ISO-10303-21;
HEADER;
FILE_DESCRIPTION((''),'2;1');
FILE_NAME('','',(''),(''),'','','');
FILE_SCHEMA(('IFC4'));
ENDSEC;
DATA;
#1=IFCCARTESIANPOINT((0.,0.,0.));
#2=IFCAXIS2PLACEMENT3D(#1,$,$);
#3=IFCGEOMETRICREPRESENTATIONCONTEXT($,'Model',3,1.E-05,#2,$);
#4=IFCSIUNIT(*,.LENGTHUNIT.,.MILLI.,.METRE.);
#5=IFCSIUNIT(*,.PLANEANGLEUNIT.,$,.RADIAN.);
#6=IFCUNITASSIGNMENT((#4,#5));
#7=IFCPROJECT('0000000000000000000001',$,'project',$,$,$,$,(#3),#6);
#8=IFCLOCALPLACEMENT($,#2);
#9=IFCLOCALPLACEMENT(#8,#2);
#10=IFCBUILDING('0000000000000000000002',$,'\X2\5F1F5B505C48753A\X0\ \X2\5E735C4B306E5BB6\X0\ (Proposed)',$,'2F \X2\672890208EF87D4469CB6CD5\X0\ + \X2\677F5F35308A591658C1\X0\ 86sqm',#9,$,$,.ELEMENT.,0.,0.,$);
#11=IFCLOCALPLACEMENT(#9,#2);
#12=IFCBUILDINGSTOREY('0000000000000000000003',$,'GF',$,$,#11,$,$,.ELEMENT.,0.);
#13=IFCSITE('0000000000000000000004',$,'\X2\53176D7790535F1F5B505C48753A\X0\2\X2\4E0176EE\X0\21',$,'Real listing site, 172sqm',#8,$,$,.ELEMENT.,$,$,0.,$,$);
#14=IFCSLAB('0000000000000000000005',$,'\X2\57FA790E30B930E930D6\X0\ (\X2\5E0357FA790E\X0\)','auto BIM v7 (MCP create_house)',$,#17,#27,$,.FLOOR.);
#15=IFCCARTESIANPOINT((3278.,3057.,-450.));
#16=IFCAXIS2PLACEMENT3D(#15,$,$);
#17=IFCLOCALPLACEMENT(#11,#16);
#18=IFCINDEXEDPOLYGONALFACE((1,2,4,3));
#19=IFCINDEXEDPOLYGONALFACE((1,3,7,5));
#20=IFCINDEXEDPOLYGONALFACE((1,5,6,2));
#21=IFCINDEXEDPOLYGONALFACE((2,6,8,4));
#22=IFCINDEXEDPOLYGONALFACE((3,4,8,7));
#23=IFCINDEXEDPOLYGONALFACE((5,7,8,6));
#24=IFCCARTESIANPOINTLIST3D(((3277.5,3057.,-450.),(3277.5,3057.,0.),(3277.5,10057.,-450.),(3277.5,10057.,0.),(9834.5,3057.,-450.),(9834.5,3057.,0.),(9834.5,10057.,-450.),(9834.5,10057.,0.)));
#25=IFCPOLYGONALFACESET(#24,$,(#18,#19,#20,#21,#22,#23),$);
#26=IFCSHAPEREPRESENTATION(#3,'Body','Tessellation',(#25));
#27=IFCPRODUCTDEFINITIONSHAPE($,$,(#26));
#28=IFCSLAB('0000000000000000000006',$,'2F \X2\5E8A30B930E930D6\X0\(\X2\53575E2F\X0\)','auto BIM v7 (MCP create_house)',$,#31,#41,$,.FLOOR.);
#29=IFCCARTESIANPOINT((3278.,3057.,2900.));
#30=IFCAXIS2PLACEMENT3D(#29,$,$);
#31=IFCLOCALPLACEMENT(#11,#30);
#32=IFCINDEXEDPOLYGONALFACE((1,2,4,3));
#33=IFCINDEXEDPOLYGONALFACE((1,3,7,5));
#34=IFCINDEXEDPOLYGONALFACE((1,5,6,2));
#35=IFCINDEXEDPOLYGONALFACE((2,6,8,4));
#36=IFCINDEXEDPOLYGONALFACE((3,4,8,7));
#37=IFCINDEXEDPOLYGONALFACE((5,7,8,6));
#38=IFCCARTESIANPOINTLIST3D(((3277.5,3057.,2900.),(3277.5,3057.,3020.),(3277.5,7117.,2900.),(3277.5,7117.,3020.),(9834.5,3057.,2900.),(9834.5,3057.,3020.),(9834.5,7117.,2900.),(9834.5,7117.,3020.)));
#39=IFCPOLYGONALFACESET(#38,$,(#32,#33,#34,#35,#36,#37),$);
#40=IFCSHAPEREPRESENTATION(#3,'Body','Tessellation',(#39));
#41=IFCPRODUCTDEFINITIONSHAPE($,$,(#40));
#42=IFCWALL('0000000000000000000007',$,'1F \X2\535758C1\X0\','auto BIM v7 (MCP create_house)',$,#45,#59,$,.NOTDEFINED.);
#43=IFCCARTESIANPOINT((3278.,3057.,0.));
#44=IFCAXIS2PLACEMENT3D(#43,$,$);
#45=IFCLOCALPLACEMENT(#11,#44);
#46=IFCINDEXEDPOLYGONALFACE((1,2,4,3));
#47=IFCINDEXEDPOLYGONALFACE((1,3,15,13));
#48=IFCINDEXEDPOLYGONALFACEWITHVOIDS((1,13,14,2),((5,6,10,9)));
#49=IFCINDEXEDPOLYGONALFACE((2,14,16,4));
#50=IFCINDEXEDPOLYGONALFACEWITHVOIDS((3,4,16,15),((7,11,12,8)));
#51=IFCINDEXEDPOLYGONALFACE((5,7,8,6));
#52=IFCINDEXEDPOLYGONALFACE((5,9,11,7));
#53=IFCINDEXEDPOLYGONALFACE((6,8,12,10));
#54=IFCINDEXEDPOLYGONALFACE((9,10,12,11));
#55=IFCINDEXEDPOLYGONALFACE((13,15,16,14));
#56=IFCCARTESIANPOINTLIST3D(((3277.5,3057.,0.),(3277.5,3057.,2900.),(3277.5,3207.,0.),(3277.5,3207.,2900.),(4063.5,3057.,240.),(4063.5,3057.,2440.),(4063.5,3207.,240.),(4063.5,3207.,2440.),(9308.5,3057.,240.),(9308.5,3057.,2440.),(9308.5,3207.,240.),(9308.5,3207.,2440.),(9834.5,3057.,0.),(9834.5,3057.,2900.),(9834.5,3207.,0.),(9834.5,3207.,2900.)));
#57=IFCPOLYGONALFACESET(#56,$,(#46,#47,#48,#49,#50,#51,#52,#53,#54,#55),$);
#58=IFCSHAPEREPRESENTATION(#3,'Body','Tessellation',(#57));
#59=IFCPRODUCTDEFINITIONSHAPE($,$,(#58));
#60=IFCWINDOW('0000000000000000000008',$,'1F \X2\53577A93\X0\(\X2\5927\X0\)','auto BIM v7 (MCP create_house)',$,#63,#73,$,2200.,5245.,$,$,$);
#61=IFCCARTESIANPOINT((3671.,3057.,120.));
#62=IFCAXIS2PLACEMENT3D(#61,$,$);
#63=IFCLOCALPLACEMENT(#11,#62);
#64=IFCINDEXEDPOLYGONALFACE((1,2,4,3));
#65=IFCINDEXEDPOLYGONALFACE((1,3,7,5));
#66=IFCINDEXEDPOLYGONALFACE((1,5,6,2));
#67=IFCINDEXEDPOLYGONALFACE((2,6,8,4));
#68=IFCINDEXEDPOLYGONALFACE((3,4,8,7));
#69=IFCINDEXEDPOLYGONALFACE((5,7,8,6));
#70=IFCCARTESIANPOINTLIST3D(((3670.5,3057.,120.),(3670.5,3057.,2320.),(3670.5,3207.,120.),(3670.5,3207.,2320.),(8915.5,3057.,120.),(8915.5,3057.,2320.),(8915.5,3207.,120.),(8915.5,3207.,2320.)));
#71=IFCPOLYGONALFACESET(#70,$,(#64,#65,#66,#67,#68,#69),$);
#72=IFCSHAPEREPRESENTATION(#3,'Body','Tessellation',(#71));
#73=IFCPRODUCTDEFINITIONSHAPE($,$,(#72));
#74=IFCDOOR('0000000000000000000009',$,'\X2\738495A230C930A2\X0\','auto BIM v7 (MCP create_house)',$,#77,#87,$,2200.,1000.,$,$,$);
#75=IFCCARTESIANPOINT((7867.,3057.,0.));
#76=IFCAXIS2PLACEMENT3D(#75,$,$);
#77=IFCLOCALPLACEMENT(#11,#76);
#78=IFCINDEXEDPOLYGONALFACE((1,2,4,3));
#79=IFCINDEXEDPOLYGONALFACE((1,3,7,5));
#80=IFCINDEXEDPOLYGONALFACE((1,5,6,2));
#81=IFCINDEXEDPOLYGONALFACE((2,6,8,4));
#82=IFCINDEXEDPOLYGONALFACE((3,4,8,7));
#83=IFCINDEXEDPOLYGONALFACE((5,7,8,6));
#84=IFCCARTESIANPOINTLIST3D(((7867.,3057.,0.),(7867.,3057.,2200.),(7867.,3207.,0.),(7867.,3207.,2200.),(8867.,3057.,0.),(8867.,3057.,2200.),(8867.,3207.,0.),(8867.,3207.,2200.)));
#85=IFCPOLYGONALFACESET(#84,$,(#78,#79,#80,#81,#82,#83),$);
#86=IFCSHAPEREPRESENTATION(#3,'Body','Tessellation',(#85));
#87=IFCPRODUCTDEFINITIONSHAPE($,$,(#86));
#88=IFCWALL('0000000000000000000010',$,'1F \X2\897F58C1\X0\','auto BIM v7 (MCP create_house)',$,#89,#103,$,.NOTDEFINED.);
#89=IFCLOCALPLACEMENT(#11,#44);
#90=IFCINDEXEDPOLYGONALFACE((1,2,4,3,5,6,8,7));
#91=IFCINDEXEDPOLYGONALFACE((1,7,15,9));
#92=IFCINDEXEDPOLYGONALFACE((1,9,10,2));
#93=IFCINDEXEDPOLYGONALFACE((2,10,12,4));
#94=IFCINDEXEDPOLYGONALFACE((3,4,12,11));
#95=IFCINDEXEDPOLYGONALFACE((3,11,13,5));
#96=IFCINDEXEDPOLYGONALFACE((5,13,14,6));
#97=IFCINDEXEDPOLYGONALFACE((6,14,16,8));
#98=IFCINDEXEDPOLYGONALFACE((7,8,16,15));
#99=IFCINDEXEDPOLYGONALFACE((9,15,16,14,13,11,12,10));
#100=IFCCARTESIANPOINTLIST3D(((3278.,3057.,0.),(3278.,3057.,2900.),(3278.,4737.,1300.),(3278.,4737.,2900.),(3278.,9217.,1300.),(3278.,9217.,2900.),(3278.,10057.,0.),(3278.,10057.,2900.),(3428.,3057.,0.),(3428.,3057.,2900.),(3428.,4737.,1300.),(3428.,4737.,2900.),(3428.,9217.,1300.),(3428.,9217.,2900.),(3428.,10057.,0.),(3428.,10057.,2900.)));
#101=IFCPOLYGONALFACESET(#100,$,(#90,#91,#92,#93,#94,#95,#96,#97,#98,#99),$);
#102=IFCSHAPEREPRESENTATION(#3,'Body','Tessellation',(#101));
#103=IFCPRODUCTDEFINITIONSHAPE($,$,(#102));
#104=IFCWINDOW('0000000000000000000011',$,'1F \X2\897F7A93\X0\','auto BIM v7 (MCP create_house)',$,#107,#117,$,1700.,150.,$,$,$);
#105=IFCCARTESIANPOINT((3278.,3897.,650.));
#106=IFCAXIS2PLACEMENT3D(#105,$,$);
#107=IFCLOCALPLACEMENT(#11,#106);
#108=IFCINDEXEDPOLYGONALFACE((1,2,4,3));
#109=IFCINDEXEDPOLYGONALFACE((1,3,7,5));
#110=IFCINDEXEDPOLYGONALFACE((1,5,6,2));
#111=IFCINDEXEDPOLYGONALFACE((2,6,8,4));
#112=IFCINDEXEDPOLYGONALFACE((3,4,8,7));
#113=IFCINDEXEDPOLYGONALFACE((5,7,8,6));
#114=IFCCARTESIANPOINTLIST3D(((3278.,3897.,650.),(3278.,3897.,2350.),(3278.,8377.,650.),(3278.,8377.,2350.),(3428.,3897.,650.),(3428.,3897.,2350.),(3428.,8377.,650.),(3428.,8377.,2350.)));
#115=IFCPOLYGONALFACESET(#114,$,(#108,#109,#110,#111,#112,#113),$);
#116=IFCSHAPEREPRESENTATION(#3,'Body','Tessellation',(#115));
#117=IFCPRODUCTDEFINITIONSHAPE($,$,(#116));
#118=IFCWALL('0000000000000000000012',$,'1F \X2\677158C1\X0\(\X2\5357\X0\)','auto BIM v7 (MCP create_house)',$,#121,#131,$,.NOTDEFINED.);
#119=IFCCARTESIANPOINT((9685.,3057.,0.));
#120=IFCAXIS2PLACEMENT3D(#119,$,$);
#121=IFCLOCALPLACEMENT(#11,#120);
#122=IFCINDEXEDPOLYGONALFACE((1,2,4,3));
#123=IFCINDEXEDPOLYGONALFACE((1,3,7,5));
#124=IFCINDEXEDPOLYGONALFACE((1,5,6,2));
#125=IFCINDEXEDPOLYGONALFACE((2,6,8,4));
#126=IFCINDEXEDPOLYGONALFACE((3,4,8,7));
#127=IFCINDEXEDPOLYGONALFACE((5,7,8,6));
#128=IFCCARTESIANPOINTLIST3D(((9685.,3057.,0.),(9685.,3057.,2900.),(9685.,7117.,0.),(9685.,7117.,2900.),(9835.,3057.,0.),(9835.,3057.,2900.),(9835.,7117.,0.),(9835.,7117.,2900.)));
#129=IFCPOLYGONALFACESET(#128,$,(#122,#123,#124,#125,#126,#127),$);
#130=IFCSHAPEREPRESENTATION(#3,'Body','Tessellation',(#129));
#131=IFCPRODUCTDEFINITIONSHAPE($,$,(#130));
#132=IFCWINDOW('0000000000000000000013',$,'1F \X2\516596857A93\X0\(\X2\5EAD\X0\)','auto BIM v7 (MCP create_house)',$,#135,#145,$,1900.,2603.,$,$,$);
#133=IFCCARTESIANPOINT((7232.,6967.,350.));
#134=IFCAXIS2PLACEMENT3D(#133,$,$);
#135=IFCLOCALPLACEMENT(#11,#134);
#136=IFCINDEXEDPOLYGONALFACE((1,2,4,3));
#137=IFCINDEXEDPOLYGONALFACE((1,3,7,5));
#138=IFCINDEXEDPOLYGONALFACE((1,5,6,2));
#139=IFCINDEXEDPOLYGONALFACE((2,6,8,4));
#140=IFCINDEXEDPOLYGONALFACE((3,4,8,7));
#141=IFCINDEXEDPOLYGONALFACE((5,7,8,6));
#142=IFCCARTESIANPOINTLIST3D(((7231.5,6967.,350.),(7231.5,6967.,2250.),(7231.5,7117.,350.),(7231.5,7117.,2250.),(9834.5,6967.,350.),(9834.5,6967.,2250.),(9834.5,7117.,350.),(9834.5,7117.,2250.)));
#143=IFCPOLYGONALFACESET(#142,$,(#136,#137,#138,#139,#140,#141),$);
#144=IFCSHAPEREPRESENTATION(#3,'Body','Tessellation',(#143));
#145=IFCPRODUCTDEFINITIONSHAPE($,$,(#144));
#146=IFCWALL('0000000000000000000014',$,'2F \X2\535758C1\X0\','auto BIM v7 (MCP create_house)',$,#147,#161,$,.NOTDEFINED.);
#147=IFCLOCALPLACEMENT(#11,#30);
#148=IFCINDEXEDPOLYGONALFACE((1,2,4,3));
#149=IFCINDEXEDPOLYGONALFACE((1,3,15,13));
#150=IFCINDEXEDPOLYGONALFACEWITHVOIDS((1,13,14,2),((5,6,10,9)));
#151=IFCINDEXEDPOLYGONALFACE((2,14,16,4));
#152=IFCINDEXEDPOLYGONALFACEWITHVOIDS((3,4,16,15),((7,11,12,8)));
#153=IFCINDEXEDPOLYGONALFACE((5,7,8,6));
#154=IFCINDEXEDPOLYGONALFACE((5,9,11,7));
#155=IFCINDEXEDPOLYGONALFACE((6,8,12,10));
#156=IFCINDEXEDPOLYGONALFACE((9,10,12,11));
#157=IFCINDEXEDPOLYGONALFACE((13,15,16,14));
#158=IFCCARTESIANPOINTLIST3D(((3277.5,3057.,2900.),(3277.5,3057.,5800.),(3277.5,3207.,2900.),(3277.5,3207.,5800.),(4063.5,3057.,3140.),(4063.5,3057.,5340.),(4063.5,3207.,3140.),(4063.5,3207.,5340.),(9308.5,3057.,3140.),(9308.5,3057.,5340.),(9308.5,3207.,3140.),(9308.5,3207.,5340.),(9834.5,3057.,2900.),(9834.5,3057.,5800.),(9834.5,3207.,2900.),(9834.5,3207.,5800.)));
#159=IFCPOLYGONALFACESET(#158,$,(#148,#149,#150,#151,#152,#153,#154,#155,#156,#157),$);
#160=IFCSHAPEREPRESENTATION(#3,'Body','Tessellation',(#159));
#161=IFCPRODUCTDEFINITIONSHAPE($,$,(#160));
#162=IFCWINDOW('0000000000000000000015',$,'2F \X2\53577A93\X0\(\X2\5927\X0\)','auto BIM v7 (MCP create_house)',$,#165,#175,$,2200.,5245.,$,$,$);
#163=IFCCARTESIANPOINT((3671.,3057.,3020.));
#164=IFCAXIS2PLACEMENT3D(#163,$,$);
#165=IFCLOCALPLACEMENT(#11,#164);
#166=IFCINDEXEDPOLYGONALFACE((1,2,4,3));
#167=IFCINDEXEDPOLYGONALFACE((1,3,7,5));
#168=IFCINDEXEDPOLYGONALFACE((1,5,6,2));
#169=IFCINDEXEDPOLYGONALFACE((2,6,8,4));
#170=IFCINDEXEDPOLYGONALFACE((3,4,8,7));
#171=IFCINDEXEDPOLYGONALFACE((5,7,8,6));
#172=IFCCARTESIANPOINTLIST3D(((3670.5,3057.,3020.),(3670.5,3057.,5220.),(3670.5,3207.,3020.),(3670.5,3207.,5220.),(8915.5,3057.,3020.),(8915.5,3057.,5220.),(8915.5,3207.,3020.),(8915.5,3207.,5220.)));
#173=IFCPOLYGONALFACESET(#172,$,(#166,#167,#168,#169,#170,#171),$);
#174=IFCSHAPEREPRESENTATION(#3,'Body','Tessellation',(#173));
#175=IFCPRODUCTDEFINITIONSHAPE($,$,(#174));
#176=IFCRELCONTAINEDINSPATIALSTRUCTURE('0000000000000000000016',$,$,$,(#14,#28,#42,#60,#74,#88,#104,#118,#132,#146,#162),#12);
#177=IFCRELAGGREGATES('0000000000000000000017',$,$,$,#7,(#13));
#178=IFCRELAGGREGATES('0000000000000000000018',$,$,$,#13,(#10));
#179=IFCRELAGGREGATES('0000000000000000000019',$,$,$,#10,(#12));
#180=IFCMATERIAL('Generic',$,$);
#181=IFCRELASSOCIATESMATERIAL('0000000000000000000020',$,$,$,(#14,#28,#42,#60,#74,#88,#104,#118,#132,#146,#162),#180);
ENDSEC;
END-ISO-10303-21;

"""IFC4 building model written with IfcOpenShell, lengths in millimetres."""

from ifc_helpers import new_model, si_unit, frame, frame_2d, origin, place, context, project, spatial, rectangle, extrude, material, element, fill, save


model = new_model("IFC4")

# Units and contexts
model_context = context("Model", 3, precision=1e-05, world=origin())
ifc_project = project(units=[si_unit("LENGTHUNIT", "METRE", prefix="MILLI"), si_unit("PLANEANGLEUNIT", "RADIAN")], contexts=[model_context])

# Site, building, storey
site_placement = place(None, origin())
site = spatial("IfcSite", under=ifc_project, at=site_placement, Name="北海道弟子屈町2丁目21", ObjectType="Real listing site, 172sqm", CompositionType="ELEMENT", RefElevation=0.0)
building_placement = place(site_placement, origin())
building = spatial("IfcBuilding", under=site, at=building_placement, Name="弟子屈町 平屋の家 (Proposed)", ObjectType="2F 木造軸組構法 + 板張り外壁 86sqm", CompositionType="ELEMENT", ElevationOfRefHeight=0.0, ElevationOfTerrain=0.0)
storey_placement = place(building_placement, origin())
storey = spatial("IfcBuildingStorey", under=building, at=storey_placement, Name="GF", CompositionType="ELEMENT", Elevation=0.0)

# Slabs
ifc_material = material(Name="Generic")
slab_1_placement = place(storey_placement, frame((3278.0, 3057.0, -450.0)))
element("IfcSlab", 1, at=slab_1_placement, inside=storey, material=ifc_material, Name="基礎スラブ (布基礎)", Description="auto BIM v7 (MCP create_house)", PredefinedType="FLOOR", context=model_context, shape_type="SweptSolid", body=[
    extrude(rectangle(XDim=6557.0, YDim=7000.0, at=frame_2d((3278.0, 3500.0))), frame((3278.0, 3057.0, -450.0)), (0.0, 0.0, 1.0), 450.0),
])
slab_2_placement = place(storey_placement, frame((3278.0, 3057.0, 2900.0)))
element("IfcSlab", 2, at=slab_2_placement, inside=storey, material=ifc_material, Name="2F 床スラブ(南帯)", Description="auto BIM v7 (MCP create_house)", PredefinedType="FLOOR", context=model_context, shape_type="SweptSolid", body=[
    extrude(rectangle(XDim=6557.0, YDim=4060.0, at=frame_2d((3278.0, 2030.0))), frame((3278.0, 3057.0, 2900.0)), (0.0, 0.0, 1.0), 120.0),
])

# Wall, openings, window, door
wall_1_placement = place(storey_placement, frame((3278.0, 3057.0, 0.0)))
wall_1 = element("IfcWall", 3, at=wall_1_placement, inside=storey, material=ifc_material, Name="1F 南壁", Description="auto BIM v7 (MCP create_house)", PredefinedType="NOTDEFINED", context=model_context, shape_type="SweptSolid", body=[
    extrude(rectangle(XDim=6557.0, YDim=150.0, at=frame_2d((3278.0, 75.0))), frame((3278.0, 3057.0, 0.0)), (0.0, 0.0, 1.0), 2900.0),
])
opening_1_placement = place(storey_placement, frame((3671.0, 3057.0, 120.0)))
opening_1 = element("IfcOpeningElement", 4, at=opening_1_placement, cuts=wall_1, PredefinedType="NOTDEFINED", context=model_context, shape_type="SweptSolid", body=[
    extrude(rectangle(XDim=5245.0, YDim=150.0, at=frame_2d((2622.0, 75.0))), frame((3671.0, 3057.0, 120.0)), (0.0, 0.0, 1.0), 2200.0),
])
opening_2_placement = place(storey_placement, frame((7867.0, 3057.0, 0.0)))
opening_2 = element("IfcOpeningElement", 5, at=opening_2_placement, cuts=wall_1, PredefinedType="NOTDEFINED", context=model_context, shape_type="SweptSolid", body=[
    extrude(rectangle(XDim=1000.0, YDim=150.0, at=frame_2d((500.0, 75.0))), frame((7867.0, 3057.0, 0.0)), (0.0, 0.0, 1.0), 2200.0),
])
window_1_placement = place(storey_placement, frame((3671.0, 3057.0, 120.0)))
window_1 = element("IfcWindow", 6, at=window_1_placement, inside=storey, material=ifc_material, Name="1F 南窓(大)", Description="auto BIM v7 (MCP create_house)", OverallHeight=2200.0, OverallWidth=5245.0, context=model_context, shape_type="SweptSolid", body=[
    extrude(rectangle(XDim=5245.0, YDim=150.0, at=frame_2d((2622.0, 75.0))), frame((3671.0, 3057.0, 120.0)), (0.0, 0.0, 1.0), 2200.0),
])
fill(opening_1, window_1)
door_placement = place(storey_placement, frame((7867.0, 3057.0, 0.0)))
door = element("IfcDoor", 7, at=door_placement, inside=storey, material=ifc_material, Name="玄関ドア", Description="auto BIM v7 (MCP create_house)", OverallHeight=2200.0, OverallWidth=1000.0, context=model_context, shape_type="SweptSolid", body=[
    extrude(rectangle(XDim=1000.0, YDim=150.0, at=frame_2d((500.0, 75.0))), frame((7867.0, 3057.0, 0.0)), (0.0, 0.0, 1.0), 2200.0),
])
fill(opening_2, door)

# Walls, openings, windows
wall_2_placement = place(storey_placement, frame((3278.0, 3057.0, 0.0)))
wall_2 = element("IfcWall", 8, at=wall_2_placement, inside=storey, material=ifc_material, Name="1F 西壁", Description="auto BIM v7 (MCP create_house)", PredefinedType="NOTDEFINED", context=model_context, shape_type="SweptSolid", body=[
    extrude(rectangle(XDim=150.0, YDim=7000.0, at=frame_2d((75.0, 3500.0))), frame((3278.0, 3057.0, 0.0)), (0.0, 0.0, 1.0), 2900.0),
])
opening_3_placement = place(storey_placement, frame((3278.0, 3897.0, 650.0)))
opening_3 = element("IfcOpeningElement", 9, at=opening_3_placement, cuts=wall_2, PredefinedType="NOTDEFINED", context=model_context, shape_type="SweptSolid", body=[
    extrude(rectangle(XDim=150.0, YDim=4480.0, at=frame_2d((75.0, 2240.0))), frame((3278.0, 3897.0, 650.0)), (0.0, 0.0, 1.0), 1700.0),
])
window_2_placement = place(storey_placement, frame((3278.0, 3897.0, 650.0)))
window_2 = element("IfcWindow", 10, at=window_2_placement, inside=storey, material=ifc_material, Name="1F 西窓", Description="auto BIM v7 (MCP create_house)", OverallHeight=1700.0, OverallWidth=150.0, context=model_context, shape_type="SweptSolid", body=[
    extrude(rectangle(XDim=150.0, YDim=4480.0, at=frame_2d((75.0, 2240.0))), frame((3278.0, 3897.0, 650.0)), (0.0, 0.0, 1.0), 1700.0),
])
fill(opening_3, window_2)
wall_3_placement = place(storey_placement, frame((9685.0, 3057.0, 0.0)))
wall_3 = element("IfcWall", 11, at=wall_3_placement, inside=storey, material=ifc_material, Name="1F 東壁(南)", Description="auto BIM v7 (MCP create_house)", PredefinedType="NOTDEFINED", context=model_context, shape_type="SweptSolid", body=[
    extrude(rectangle(XDim=150.0, YDim=4060.0, at=frame_2d((75.0, 2030.0))), frame((9685.0, 3057.0, 0.0)), (0.0, 0.0, 1.0), 2900.0),
])
opening_4_placement = place(storey_placement, frame((7232.0, 6967.0, 350.0)))
opening_4 = element("IfcOpeningElement", 12, at=opening_4_placement, cuts=wall_3, PredefinedType="NOTDEFINED", context=model_context, shape_type="SweptSolid", body=[
    extrude(rectangle(XDim=2603.0, YDim=150.0, at=frame_2d((1301.0, 75.0))), frame((7232.0, 6967.0, 350.0)), (0.0, 0.0, 1.0), 1900.0),
])
window_3_placement = place(storey_placement, frame((7232.0, 6967.0, 350.0)))
window_3 = element("IfcWindow", 13, at=window_3_placement, inside=storey, material=ifc_material, Name="1F 入隅窓(庭)", Description="auto BIM v7 (MCP create_house)", OverallHeight=1900.0, OverallWidth=2603.0, context=model_context, shape_type="SweptSolid", body=[
    extrude(rectangle(XDim=2603.0, YDim=150.0, at=frame_2d((1301.0, 75.0))), frame((7232.0, 6967.0, 350.0)), (0.0, 0.0, 1.0), 1900.0),
])
fill(opening_4, window_3)

# Wall, opening, window
wall_4_placement = place(storey_placement, frame((3278.0, 3057.0, 2900.0)))
wall_4 = element("IfcWall", 14, at=wall_4_placement, inside=storey, material=ifc_material, Name="2F 南壁", Description="auto BIM v7 (MCP create_house)", PredefinedType="NOTDEFINED", context=model_context, shape_type="SweptSolid", body=[
    extrude(rectangle(XDim=6557.0, YDim=150.0, at=frame_2d((3278.0, 75.0))), frame((3278.0, 3057.0, 2900.0)), (0.0, 0.0, 1.0), 2900.0),
])
opening_5_placement = place(storey_placement, frame((3671.0, 3057.0, 3020.0)))
opening_5 = element("IfcOpeningElement", 15, at=opening_5_placement, cuts=wall_4, PredefinedType="NOTDEFINED", context=model_context, shape_type="SweptSolid", body=[
    extrude(rectangle(XDim=5245.0, YDim=150.0, at=frame_2d((2622.0, 75.0))), frame((3671.0, 3057.0, 3020.0)), (0.0, 0.0, 1.0), 2200.0),
])
window_4_placement = place(storey_placement, frame((3671.0, 3057.0, 3020.0)))
window_4 = element("IfcWindow", 16, at=window_4_placement, inside=storey, material=ifc_material, Name="2F 南窓(大)", Description="auto BIM v7 (MCP create_house)", OverallHeight=2200.0, OverallWidth=5245.0, context=model_context, shape_type="SweptSolid", body=[
    extrude(rectangle(XDim=5245.0, YDim=150.0, at=frame_2d((2622.0, 75.0))), frame((3671.0, 3057.0, 3020.0)), (0.0, 0.0, 1.0), 2200.0),
])
fill(opening_5, window_4)

save(model, "model.ifc")
